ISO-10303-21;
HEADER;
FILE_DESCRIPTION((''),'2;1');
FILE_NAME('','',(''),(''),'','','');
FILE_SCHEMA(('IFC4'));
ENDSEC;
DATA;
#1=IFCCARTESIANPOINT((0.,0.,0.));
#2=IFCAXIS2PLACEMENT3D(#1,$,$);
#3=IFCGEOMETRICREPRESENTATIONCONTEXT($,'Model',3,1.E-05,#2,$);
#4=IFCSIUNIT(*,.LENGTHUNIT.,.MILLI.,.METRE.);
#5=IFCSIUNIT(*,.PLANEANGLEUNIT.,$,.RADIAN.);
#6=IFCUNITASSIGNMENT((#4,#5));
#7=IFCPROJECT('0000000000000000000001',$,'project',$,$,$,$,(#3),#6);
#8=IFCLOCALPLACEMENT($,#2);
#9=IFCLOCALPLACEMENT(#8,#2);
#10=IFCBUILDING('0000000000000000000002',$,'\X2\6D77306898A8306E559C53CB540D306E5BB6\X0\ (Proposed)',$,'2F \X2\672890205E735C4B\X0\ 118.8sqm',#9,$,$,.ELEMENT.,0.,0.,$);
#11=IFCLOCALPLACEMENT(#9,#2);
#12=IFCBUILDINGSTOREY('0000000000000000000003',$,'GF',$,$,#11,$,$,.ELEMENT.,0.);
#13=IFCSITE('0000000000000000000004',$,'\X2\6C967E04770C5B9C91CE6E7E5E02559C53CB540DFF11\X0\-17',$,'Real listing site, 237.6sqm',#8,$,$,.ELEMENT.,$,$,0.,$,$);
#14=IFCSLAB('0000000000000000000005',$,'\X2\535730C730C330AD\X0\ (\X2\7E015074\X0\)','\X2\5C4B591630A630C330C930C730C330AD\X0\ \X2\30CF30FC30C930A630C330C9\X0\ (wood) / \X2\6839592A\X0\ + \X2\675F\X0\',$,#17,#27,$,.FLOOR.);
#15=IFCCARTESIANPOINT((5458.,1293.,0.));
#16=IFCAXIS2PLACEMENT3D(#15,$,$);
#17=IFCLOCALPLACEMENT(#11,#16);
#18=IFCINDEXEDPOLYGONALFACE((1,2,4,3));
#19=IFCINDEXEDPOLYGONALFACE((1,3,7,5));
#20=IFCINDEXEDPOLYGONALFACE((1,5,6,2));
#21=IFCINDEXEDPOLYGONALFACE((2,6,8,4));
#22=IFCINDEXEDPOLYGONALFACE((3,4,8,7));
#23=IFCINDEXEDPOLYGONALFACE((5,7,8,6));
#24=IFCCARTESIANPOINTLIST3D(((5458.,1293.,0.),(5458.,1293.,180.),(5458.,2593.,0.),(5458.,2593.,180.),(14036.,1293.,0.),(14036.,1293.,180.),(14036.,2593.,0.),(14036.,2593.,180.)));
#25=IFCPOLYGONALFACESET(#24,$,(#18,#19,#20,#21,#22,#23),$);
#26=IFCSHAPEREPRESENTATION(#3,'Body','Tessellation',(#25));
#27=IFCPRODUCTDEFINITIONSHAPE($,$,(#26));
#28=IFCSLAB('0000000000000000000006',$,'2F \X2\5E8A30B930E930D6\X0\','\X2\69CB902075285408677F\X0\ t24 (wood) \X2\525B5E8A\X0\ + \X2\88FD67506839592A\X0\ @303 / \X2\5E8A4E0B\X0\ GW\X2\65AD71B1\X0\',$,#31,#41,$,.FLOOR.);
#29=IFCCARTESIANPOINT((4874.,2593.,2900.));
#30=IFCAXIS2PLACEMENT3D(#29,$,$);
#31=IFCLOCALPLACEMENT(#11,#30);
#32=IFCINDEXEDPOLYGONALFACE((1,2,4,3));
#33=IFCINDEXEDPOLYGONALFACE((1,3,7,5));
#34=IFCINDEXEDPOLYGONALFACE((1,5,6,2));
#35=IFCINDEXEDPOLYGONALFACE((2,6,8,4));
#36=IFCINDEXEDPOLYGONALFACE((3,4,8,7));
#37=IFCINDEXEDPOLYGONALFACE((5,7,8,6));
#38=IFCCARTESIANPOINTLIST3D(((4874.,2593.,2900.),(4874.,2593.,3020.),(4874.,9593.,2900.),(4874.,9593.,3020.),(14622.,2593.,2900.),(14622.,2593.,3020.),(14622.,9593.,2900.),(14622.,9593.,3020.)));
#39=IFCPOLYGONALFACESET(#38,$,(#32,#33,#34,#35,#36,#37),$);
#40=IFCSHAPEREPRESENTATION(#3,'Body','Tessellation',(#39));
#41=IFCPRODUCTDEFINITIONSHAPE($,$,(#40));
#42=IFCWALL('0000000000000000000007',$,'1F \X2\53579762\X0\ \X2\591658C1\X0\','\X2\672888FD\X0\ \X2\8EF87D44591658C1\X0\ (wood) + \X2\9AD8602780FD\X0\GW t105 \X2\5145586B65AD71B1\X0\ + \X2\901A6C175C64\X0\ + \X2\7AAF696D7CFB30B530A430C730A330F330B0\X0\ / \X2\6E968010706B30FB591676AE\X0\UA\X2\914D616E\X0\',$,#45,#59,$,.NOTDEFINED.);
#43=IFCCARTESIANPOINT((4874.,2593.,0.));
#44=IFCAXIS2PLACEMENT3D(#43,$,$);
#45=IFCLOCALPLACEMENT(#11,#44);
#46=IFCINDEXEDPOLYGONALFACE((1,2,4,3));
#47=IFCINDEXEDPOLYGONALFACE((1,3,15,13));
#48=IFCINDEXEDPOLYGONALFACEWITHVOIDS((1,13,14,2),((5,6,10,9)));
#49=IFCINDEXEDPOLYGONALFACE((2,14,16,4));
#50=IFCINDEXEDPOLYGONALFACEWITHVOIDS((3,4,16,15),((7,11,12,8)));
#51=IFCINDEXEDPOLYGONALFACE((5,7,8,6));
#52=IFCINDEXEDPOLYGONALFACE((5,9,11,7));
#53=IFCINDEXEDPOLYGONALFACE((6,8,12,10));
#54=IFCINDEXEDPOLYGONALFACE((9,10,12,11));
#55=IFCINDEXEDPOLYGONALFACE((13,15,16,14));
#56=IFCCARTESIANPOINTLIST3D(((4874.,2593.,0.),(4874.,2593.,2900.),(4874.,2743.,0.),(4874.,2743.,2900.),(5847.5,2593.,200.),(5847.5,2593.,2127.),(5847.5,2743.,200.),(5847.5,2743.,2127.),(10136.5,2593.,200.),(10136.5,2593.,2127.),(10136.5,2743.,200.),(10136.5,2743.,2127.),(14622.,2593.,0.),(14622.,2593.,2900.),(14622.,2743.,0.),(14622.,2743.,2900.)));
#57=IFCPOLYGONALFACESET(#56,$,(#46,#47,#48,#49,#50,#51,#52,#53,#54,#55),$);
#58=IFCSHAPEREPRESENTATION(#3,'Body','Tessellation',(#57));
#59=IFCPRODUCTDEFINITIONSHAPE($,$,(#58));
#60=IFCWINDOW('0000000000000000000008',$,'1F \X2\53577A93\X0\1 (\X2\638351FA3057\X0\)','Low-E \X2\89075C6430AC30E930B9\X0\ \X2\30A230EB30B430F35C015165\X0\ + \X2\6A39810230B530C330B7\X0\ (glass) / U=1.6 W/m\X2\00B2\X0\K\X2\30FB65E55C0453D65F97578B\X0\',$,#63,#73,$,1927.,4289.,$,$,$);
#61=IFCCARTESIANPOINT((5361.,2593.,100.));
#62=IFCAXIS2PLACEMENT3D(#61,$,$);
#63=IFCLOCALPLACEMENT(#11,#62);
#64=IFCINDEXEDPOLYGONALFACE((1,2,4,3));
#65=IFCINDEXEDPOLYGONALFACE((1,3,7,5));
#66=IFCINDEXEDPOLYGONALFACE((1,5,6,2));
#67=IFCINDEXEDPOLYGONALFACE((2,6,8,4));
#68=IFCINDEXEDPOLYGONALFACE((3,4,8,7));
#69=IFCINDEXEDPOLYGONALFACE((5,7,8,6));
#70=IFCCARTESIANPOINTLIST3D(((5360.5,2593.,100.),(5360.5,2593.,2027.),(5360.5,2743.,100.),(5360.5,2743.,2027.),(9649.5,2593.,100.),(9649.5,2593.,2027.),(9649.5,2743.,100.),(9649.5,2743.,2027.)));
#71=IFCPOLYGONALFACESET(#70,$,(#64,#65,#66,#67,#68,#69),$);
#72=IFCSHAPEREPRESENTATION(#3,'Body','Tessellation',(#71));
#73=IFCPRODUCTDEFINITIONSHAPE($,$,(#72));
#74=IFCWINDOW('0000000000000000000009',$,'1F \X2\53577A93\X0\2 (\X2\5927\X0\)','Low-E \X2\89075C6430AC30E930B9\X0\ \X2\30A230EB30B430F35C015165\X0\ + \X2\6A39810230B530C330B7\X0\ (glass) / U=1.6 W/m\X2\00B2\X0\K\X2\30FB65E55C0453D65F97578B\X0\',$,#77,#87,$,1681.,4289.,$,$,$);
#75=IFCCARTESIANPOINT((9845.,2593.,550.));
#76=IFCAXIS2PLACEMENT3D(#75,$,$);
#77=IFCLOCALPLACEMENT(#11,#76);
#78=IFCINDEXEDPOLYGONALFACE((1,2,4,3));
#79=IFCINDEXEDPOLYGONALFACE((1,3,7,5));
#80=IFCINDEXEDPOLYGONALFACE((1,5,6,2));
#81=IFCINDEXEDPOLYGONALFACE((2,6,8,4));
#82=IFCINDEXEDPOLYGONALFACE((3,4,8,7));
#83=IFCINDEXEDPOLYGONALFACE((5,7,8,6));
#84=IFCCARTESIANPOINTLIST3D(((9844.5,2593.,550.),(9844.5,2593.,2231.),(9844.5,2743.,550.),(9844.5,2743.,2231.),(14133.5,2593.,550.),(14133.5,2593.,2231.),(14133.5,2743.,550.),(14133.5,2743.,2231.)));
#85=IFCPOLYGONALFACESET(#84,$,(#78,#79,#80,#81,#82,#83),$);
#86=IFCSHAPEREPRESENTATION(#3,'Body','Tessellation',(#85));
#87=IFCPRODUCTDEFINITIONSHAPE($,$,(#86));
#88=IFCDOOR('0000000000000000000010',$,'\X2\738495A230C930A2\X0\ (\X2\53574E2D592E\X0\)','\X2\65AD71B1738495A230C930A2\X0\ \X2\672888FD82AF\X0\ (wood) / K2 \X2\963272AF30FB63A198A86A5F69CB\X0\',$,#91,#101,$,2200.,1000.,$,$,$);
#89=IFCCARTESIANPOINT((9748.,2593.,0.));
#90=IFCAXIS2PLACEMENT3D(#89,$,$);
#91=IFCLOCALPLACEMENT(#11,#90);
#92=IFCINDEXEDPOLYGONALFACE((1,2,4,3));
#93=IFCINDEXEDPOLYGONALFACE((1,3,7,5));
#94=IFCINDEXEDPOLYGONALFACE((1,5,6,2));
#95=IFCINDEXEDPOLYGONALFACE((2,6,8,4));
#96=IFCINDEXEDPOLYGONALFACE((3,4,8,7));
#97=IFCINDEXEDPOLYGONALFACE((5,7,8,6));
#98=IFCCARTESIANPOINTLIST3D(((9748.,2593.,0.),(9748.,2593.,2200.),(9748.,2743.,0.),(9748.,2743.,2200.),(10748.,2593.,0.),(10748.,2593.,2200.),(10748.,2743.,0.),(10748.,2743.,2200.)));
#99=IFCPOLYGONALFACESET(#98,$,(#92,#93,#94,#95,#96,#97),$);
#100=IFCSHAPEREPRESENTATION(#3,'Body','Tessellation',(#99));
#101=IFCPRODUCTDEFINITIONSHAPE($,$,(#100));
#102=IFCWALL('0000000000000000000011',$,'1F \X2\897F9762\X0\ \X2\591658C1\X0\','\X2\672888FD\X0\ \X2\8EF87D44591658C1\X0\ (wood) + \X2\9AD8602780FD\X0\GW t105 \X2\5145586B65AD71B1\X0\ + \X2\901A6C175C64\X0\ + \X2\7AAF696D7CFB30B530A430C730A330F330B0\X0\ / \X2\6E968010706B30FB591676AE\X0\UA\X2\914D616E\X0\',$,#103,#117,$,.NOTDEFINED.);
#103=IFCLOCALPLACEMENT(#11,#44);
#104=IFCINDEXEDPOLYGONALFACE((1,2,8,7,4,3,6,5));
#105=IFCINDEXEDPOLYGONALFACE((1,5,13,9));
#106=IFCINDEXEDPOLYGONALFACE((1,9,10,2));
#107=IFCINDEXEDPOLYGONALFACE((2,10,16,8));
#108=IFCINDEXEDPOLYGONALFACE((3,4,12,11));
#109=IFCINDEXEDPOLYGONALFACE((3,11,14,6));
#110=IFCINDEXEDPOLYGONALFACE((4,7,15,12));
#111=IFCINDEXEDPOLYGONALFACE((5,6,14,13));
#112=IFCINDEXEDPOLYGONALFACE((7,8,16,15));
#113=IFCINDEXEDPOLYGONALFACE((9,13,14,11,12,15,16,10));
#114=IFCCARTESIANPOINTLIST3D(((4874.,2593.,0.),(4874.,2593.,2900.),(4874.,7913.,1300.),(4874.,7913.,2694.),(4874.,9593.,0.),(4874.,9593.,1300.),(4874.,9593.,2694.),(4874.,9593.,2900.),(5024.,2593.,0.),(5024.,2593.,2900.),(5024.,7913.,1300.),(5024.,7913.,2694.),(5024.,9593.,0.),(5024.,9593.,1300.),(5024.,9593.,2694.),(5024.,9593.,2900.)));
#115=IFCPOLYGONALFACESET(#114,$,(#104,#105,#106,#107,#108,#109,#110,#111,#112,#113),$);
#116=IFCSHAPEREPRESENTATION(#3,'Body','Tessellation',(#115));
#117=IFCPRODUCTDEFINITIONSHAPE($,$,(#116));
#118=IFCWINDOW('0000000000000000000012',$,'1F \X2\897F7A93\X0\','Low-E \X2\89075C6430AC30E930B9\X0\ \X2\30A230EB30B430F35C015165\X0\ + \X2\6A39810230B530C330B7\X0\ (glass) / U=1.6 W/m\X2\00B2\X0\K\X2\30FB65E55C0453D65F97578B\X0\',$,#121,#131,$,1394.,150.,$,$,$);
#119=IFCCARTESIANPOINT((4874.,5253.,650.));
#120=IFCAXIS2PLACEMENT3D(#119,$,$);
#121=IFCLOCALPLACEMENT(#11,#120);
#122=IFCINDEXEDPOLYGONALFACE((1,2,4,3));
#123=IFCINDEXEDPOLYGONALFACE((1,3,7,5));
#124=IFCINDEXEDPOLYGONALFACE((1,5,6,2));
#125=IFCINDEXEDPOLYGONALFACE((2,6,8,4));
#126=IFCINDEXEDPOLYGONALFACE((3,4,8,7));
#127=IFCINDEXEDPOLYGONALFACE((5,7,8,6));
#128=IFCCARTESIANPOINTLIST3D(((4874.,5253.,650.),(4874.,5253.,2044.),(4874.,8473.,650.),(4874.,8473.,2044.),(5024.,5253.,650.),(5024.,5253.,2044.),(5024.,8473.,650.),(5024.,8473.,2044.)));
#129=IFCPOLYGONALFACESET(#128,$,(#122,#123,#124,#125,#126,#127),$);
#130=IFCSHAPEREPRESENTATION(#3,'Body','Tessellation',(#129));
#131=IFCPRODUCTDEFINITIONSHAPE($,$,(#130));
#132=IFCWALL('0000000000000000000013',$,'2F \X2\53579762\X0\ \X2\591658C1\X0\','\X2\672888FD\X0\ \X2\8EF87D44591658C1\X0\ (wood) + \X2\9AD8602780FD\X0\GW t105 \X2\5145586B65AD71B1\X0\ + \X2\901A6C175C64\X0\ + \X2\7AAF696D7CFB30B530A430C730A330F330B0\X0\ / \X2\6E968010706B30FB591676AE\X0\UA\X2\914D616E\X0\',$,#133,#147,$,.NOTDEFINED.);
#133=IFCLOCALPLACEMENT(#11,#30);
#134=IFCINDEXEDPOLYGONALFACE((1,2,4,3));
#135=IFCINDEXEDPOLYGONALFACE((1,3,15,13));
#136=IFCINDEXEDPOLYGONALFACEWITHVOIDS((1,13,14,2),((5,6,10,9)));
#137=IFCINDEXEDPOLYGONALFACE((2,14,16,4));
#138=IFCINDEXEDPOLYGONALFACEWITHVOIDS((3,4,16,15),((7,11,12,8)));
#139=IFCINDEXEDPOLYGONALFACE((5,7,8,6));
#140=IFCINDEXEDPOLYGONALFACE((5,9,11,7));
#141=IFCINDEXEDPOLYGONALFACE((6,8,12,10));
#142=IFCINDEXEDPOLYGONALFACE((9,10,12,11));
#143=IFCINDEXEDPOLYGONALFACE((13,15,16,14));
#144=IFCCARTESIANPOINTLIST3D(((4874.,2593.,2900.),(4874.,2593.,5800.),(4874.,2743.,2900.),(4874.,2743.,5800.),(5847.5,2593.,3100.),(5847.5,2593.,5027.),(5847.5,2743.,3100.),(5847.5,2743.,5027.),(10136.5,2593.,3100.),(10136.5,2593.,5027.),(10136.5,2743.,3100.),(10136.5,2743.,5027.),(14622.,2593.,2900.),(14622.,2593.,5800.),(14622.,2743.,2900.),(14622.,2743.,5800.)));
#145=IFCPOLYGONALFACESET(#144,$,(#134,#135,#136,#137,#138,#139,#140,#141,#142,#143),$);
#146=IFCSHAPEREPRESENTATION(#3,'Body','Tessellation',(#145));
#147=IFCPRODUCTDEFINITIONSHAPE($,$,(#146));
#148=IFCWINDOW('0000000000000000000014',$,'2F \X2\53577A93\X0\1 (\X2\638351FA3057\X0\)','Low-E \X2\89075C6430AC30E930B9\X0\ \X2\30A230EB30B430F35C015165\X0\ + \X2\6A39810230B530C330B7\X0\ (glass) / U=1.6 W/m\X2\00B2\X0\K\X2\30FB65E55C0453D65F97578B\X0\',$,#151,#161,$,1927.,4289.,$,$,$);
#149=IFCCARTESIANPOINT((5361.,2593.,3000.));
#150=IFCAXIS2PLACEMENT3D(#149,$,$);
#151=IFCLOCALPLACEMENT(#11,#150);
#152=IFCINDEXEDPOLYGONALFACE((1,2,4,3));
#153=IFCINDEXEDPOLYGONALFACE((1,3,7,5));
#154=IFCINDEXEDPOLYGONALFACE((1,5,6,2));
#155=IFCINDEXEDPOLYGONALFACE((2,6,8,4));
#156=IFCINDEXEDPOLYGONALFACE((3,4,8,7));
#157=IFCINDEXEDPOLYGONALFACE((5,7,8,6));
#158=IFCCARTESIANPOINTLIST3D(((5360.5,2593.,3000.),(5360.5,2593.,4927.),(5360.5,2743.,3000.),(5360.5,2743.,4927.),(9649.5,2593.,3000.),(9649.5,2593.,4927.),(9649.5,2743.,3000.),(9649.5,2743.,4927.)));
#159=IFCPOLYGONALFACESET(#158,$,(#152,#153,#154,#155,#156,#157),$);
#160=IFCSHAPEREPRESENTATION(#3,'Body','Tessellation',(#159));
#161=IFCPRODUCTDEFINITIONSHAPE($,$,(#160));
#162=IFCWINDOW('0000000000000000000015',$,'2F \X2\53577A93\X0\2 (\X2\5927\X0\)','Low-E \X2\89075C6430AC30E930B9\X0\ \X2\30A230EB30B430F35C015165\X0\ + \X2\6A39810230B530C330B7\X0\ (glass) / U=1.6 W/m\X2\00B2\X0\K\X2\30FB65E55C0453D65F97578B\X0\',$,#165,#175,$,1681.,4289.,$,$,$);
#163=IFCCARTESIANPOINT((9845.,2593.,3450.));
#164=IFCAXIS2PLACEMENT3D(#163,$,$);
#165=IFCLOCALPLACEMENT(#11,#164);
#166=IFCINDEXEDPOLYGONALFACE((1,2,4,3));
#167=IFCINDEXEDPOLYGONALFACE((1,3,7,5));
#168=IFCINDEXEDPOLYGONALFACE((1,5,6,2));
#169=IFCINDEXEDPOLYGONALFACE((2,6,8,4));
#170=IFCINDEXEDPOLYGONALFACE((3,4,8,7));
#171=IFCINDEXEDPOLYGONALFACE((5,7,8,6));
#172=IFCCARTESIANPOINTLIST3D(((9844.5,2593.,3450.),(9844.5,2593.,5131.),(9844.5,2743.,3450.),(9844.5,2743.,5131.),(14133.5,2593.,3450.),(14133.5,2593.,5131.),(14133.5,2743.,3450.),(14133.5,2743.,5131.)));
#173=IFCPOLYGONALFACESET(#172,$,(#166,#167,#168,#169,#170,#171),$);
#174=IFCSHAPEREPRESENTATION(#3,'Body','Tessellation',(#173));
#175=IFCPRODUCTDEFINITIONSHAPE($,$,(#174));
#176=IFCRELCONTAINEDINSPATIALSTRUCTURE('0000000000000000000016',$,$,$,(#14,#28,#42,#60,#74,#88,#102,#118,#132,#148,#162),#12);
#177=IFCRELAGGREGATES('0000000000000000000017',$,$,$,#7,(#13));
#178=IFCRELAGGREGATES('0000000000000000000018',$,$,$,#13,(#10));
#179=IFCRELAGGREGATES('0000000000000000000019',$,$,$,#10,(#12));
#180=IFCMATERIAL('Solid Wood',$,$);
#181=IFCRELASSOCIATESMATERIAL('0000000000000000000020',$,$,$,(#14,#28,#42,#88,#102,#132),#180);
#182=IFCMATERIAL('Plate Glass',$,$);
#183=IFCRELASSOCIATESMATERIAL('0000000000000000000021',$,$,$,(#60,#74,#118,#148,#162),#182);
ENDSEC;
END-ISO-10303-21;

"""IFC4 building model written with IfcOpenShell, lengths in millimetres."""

from ifc_helpers import new_model, si_unit, frame, frame_2d, origin, place, context, project, spatial, rectangle, extrude, material, element, fill, save


model = new_model("IFC4")

# Units and contexts
model_context = context("Model", 3, precision=1e-05, world=origin())
ifc_project = project(units=[si_unit("LENGTHUNIT", "METRE", prefix="MILLI"), si_unit("PLANEANGLEUNIT", "RADIAN")], contexts=[model_context])

# Site, building, storey
site_placement = place(None, origin())
site = spatial("IfcSite", under=ifc_project, at=site_placement, Name="沖縄県宜野湾市喜友名１-17", ObjectType="Real listing site, 237.6sqm", CompositionType="ELEMENT", RefElevation=0.0)
building_placement = place(site_placement, origin())
building = spatial("IfcBuilding", under=site, at=building_placement, Name="海と風の喜友名の家 (Proposed)", ObjectType="2F 木造平屋 118.8sqm", CompositionType="ELEMENT", ElevationOfRefHeight=0.0, ElevationOfTerrain=0.0)
storey_placement = place(building_placement, origin())
storey = spatial("IfcBuildingStorey", under=building, at=storey_placement, Name="GF", CompositionType="ELEMENT", Elevation=0.0)

# Slabs
ifc_material_1 = material(Name="Solid Wood")
slab_1_placement = place(storey_placement, frame((5458.0, 1293.0, 0.0)))
element("IfcSlab", 1, at=slab_1_placement, inside=storey, material=ifc_material_1, Name="南デッキ (縁側)", Description="屋外ウッドデッキ ハードウッド (wood) / 根太 + 束", PredefinedType="FLOOR", context=model_context, shape_type="SweptSolid", body=[
    extrude(rectangle(XDim=8578.0, YDim=1300.0, at=frame_2d((4289.0, 650.0))), frame((5458.0, 1293.0, 0.0)), (0.0, 0.0, 1.0), 180.0),
])
slab_2_placement = place(storey_placement, frame((4874.0, 2593.0, 2900.0)))
element("IfcSlab", 2, at=slab_2_placement, inside=storey, material=ifc_material_1, Name="2F 床スラブ", Description="構造用合板 t24 (wood) 剛床 + 製材根太 @303 / 床下 GW断熱", PredefinedType="FLOOR", context=model_context, shape_type="SweptSolid", body=[
    extrude(rectangle(XDim=9748.0, YDim=7000.0, at=frame_2d((4874.0, 3500.0))), frame((4874.0, 2593.0, 2900.0)), (0.0, 0.0, 1.0), 120.0),
])

# Wall, openings, windows, door
wall_1_placement = place(storey_placement, frame((4874.0, 2593.0, 0.0)))
wall_1 = element("IfcWall", 3, at=wall_1_placement, inside=storey, material=ifc_material_1, Name="1F 南面 外壁", Description="木製 軸組外壁 (wood) + 高性能GW t105 充填断熱 + 通気層 + 窯業系サイディング / 準耐火・外皮UA配慮", PredefinedType="NOTDEFINED", context=model_context, shape_type="SweptSolid", body=[
    extrude(rectangle(XDim=9748.0, YDim=150.0, at=frame_2d((4874.0, 75.0))), frame((4874.0, 2593.0, 0.0)), (0.0, 0.0, 1.0), 2900.0),
])
opening_1_placement = place(storey_placement, frame((5361.0, 2593.0, 100.0)))
opening_1 = element("IfcOpeningElement", 4, at=opening_1_placement, cuts=wall_1, PredefinedType="NOTDEFINED", context=model_context, shape_type="SweptSolid", body=[
    extrude(rectangle(XDim=4289.0, YDim=150.0, at=frame_2d((2144.0, 75.0))), frame((5361.0, 2593.0, 100.0)), (0.0, 0.0, 1.0), 1927.0),
])
opening_2_placement = place(storey_placement, frame((9845.0, 2593.0, 550.0)))
opening_2 = element("IfcOpeningElement", 5, at=opening_2_placement, cuts=wall_1, PredefinedType="NOTDEFINED", context=model_context, shape_type="SweptSolid", body=[
    extrude(rectangle(XDim=4289.0, YDim=150.0, at=frame_2d((2144.0, 75.0))), frame((9845.0, 2593.0, 550.0)), (0.0, 0.0, 1.0), 1681.0),
])
opening_3_placement = place(storey_placement, frame((9748.0, 2593.0, 0.0)))
opening_3 = element("IfcOpeningElement", 6, at=opening_3_placement, cuts=wall_1, PredefinedType="NOTDEFINED", context=model_context, shape_type="SweptSolid", body=[
    extrude(rectangle(XDim=1000.0, YDim=150.0, at=frame_2d((500.0, 75.0))), frame((9748.0, 2593.0, 0.0)), (0.0, 0.0, 1.0), 2200.0),
])
ifc_material_2 = material(Name="Plate Glass")
window_1_placement = place(storey_placement, frame((5361.0, 2593.0, 100.0)))
window_1 = element("IfcWindow", 7, at=window_1_placement, inside=storey, material=ifc_material_2, Name="1F 南窓1 (掃出し)", Description="Low-E 複層ガラス アルゴン封入 + 樹脂サッシ (glass) / U=1.6 W/m²K・日射取得型", OverallHeight=1927.0, OverallWidth=4289.0, context=model_context, shape_type="SweptSolid", body=[
    extrude(rectangle(XDim=4289.0, YDim=150.0, at=frame_2d((2144.0, 75.0))), frame((5361.0, 2593.0, 100.0)), (0.0, 0.0, 1.0), 1927.0),
])
fill(opening_1, window_1)
window_2_placement = place(storey_placement, frame((9845.0, 2593.0, 550.0)))
window_2 = element("IfcWindow", 8, at=window_2_placement, inside=storey, material=ifc_material_2, Name="1F 南窓2 (大)", Description="Low-E 複層ガラス アルゴン封入 + 樹脂サッシ (glass) / U=1.6 W/m²K・日射取得型", OverallHeight=1681.0, OverallWidth=4289.0, context=model_context, shape_type="SweptSolid", body=[
    extrude(rectangle(XDim=4289.0, YDim=150.0, at=frame_2d((2144.0, 75.0))), frame((9845.0, 2593.0, 550.0)), (0.0, 0.0, 1.0), 1681.0),
])
fill(opening_2, window_2)
door_placement = place(storey_placement, frame((9748.0, 2593.0, 0.0)))
door = element("IfcDoor", 9, at=door_placement, inside=storey, material=ifc_material_1, Name="玄関ドア (南中央)", Description="断熱玄関ドア 木製芯 (wood) / K2 防犯・採風機構", OverallHeight=2200.0, OverallWidth=1000.0, context=model_context, shape_type="SweptSolid", body=[
    extrude(rectangle(XDim=1000.0, YDim=150.0, at=frame_2d((500.0, 75.0))), frame((9748.0, 2593.0, 0.0)), (0.0, 0.0, 1.0), 2200.0),
])
fill(opening_3, door)

# Wall, opening, window
wall_2_placement = place(storey_placement, frame((4874.0, 2593.0, 0.0)))
wall_2 = element("IfcWall", 10, at=wall_2_placement, inside=storey, material=ifc_material_1, Name="1F 西面 外壁", Description="木製 軸組外壁 (wood) + 高性能GW t105 充填断熱 + 通気層 + 窯業系サイディング / 準耐火・外皮UA配慮", PredefinedType="NOTDEFINED", context=model_context, shape_type="SweptSolid", body=[
    extrude(rectangle(XDim=150.0, YDim=7000.0, at=frame_2d((75.0, 3500.0))), frame((4874.0, 2593.0, 0.0)), (0.0, 0.0, 1.0), 2900.0),
])
opening_4_placement = place(storey_placement, frame((4874.0, 5253.0, 650.0)))
opening_4 = element("IfcOpeningElement", 11, at=opening_4_placement, cuts=wall_2, PredefinedType="NOTDEFINED", context=model_context, shape_type="SweptSolid", body=[
    extrude(rectangle(XDim=150.0, YDim=3220.0, at=frame_2d((75.0, 1610.0))), frame((4874.0, 5253.0, 650.0)), (0.0, 0.0, 1.0), 1394.0),
])
window_3_placement = place(storey_placement, frame((4874.0, 5253.0, 650.0)))
window_3 = element("IfcWindow", 12, at=window_3_placement, inside=storey, material=ifc_material_2, Name="1F 西窓", Description="Low-E 複層ガラス アルゴン封入 + 樹脂サッシ (glass) / U=1.6 W/m²K・日射取得型", OverallHeight=1394.0, OverallWidth=150.0, context=model_context, shape_type="SweptSolid", body=[
    extrude(rectangle(XDim=150.0, YDim=3220.0, at=frame_2d((75.0, 1610.0))), frame((4874.0, 5253.0, 650.0)), (0.0, 0.0, 1.0), 1394.0),
])
fill(opening_4, window_3)

# Wall, openings, windows
wall_3_placement = place(storey_placement, frame((4874.0, 2593.0, 2900.0)))
wall_3 = element("IfcWall", 13, at=wall_3_placement, inside=storey, material=ifc_material_1, Name="2F 南面 外壁", Description="木製 軸組外壁 (wood) + 高性能GW t105 充填断熱 + 通気層 + 窯業系サイディング / 準耐火・外皮UA配慮", PredefinedType="NOTDEFINED", context=model_context, shape_type="SweptSolid", body=[
    extrude(rectangle(XDim=9748.0, YDim=150.0, at=frame_2d((4874.0, 75.0))), frame((4874.0, 2593.0, 2900.0)), (0.0, 0.0, 1.0), 2900.0),
])
opening_5_placement = place(storey_placement, frame((5361.0, 2593.0, 3000.0)))
opening_5 = element("IfcOpeningElement", 14, at=opening_5_placement, cuts=wall_3, PredefinedType="NOTDEFINED", context=model_context, shape_type="SweptSolid", body=[
    extrude(rectangle(XDim=4289.0, YDim=150.0, at=frame_2d((2144.0, 75.0))), frame((5361.0, 2593.0, 3000.0)), (0.0, 0.0, 1.0), 1927.0),
])
opening_6_placement = place(storey_placement, frame((9845.0, 2593.0, 3450.0)))
opening_6 = element("IfcOpeningElement", 15, at=opening_6_placement, cuts=wall_3, PredefinedType="NOTDEFINED", context=model_context, shape_type="SweptSolid", body=[
    extrude(rectangle(XDim=4289.0, YDim=150.0, at=frame_2d((2144.0, 75.0))), frame((9845.0, 2593.0, 3450.0)), (0.0, 0.0, 1.0), 1681.0),
])
window_4_placement = place(storey_placement, frame((5361.0, 2593.0, 3000.0)))
window_4 = element("IfcWindow", 16, at=window_4_placement, inside=storey, material=ifc_material_2, Name="2F 南窓1 (掃出し)", Description="Low-E 複層ガラス アルゴン封入 + 樹脂サッシ (glass) / U=1.6 W/m²K・日射取得型", OverallHeight=1927.0, OverallWidth=4289.0, context=model_context, shape_type="SweptSolid", body=[
    extrude(rectangle(XDim=4289.0, YDim=150.0, at=frame_2d((2144.0, 75.0))), frame((5361.0, 2593.0, 3000.0)), (0.0, 0.0, 1.0), 1927.0),
])
fill(opening_5, window_4)
window_5_placement = place(storey_placement, frame((9845.0, 2593.0, 3450.0)))
window_5 = element("IfcWindow", 17, at=window_5_placement, inside=storey, material=ifc_material_2, Name="2F 南窓2 (大)", Description="Low-E 複層ガラス アルゴン封入 + 樹脂サッシ (glass) / U=1.6 W/m²K・日射取得型", OverallHeight=1681.0, OverallWidth=4289.0, context=model_context, shape_type="SweptSolid", body=[
    extrude(rectangle(XDim=4289.0, YDim=150.0, at=frame_2d((2144.0, 75.0))), frame((9845.0, 2593.0, 3450.0)), (0.0, 0.0, 1.0), 1681.0),
])
fill(opening_6, window_5)

save(model, "model.ifc")
